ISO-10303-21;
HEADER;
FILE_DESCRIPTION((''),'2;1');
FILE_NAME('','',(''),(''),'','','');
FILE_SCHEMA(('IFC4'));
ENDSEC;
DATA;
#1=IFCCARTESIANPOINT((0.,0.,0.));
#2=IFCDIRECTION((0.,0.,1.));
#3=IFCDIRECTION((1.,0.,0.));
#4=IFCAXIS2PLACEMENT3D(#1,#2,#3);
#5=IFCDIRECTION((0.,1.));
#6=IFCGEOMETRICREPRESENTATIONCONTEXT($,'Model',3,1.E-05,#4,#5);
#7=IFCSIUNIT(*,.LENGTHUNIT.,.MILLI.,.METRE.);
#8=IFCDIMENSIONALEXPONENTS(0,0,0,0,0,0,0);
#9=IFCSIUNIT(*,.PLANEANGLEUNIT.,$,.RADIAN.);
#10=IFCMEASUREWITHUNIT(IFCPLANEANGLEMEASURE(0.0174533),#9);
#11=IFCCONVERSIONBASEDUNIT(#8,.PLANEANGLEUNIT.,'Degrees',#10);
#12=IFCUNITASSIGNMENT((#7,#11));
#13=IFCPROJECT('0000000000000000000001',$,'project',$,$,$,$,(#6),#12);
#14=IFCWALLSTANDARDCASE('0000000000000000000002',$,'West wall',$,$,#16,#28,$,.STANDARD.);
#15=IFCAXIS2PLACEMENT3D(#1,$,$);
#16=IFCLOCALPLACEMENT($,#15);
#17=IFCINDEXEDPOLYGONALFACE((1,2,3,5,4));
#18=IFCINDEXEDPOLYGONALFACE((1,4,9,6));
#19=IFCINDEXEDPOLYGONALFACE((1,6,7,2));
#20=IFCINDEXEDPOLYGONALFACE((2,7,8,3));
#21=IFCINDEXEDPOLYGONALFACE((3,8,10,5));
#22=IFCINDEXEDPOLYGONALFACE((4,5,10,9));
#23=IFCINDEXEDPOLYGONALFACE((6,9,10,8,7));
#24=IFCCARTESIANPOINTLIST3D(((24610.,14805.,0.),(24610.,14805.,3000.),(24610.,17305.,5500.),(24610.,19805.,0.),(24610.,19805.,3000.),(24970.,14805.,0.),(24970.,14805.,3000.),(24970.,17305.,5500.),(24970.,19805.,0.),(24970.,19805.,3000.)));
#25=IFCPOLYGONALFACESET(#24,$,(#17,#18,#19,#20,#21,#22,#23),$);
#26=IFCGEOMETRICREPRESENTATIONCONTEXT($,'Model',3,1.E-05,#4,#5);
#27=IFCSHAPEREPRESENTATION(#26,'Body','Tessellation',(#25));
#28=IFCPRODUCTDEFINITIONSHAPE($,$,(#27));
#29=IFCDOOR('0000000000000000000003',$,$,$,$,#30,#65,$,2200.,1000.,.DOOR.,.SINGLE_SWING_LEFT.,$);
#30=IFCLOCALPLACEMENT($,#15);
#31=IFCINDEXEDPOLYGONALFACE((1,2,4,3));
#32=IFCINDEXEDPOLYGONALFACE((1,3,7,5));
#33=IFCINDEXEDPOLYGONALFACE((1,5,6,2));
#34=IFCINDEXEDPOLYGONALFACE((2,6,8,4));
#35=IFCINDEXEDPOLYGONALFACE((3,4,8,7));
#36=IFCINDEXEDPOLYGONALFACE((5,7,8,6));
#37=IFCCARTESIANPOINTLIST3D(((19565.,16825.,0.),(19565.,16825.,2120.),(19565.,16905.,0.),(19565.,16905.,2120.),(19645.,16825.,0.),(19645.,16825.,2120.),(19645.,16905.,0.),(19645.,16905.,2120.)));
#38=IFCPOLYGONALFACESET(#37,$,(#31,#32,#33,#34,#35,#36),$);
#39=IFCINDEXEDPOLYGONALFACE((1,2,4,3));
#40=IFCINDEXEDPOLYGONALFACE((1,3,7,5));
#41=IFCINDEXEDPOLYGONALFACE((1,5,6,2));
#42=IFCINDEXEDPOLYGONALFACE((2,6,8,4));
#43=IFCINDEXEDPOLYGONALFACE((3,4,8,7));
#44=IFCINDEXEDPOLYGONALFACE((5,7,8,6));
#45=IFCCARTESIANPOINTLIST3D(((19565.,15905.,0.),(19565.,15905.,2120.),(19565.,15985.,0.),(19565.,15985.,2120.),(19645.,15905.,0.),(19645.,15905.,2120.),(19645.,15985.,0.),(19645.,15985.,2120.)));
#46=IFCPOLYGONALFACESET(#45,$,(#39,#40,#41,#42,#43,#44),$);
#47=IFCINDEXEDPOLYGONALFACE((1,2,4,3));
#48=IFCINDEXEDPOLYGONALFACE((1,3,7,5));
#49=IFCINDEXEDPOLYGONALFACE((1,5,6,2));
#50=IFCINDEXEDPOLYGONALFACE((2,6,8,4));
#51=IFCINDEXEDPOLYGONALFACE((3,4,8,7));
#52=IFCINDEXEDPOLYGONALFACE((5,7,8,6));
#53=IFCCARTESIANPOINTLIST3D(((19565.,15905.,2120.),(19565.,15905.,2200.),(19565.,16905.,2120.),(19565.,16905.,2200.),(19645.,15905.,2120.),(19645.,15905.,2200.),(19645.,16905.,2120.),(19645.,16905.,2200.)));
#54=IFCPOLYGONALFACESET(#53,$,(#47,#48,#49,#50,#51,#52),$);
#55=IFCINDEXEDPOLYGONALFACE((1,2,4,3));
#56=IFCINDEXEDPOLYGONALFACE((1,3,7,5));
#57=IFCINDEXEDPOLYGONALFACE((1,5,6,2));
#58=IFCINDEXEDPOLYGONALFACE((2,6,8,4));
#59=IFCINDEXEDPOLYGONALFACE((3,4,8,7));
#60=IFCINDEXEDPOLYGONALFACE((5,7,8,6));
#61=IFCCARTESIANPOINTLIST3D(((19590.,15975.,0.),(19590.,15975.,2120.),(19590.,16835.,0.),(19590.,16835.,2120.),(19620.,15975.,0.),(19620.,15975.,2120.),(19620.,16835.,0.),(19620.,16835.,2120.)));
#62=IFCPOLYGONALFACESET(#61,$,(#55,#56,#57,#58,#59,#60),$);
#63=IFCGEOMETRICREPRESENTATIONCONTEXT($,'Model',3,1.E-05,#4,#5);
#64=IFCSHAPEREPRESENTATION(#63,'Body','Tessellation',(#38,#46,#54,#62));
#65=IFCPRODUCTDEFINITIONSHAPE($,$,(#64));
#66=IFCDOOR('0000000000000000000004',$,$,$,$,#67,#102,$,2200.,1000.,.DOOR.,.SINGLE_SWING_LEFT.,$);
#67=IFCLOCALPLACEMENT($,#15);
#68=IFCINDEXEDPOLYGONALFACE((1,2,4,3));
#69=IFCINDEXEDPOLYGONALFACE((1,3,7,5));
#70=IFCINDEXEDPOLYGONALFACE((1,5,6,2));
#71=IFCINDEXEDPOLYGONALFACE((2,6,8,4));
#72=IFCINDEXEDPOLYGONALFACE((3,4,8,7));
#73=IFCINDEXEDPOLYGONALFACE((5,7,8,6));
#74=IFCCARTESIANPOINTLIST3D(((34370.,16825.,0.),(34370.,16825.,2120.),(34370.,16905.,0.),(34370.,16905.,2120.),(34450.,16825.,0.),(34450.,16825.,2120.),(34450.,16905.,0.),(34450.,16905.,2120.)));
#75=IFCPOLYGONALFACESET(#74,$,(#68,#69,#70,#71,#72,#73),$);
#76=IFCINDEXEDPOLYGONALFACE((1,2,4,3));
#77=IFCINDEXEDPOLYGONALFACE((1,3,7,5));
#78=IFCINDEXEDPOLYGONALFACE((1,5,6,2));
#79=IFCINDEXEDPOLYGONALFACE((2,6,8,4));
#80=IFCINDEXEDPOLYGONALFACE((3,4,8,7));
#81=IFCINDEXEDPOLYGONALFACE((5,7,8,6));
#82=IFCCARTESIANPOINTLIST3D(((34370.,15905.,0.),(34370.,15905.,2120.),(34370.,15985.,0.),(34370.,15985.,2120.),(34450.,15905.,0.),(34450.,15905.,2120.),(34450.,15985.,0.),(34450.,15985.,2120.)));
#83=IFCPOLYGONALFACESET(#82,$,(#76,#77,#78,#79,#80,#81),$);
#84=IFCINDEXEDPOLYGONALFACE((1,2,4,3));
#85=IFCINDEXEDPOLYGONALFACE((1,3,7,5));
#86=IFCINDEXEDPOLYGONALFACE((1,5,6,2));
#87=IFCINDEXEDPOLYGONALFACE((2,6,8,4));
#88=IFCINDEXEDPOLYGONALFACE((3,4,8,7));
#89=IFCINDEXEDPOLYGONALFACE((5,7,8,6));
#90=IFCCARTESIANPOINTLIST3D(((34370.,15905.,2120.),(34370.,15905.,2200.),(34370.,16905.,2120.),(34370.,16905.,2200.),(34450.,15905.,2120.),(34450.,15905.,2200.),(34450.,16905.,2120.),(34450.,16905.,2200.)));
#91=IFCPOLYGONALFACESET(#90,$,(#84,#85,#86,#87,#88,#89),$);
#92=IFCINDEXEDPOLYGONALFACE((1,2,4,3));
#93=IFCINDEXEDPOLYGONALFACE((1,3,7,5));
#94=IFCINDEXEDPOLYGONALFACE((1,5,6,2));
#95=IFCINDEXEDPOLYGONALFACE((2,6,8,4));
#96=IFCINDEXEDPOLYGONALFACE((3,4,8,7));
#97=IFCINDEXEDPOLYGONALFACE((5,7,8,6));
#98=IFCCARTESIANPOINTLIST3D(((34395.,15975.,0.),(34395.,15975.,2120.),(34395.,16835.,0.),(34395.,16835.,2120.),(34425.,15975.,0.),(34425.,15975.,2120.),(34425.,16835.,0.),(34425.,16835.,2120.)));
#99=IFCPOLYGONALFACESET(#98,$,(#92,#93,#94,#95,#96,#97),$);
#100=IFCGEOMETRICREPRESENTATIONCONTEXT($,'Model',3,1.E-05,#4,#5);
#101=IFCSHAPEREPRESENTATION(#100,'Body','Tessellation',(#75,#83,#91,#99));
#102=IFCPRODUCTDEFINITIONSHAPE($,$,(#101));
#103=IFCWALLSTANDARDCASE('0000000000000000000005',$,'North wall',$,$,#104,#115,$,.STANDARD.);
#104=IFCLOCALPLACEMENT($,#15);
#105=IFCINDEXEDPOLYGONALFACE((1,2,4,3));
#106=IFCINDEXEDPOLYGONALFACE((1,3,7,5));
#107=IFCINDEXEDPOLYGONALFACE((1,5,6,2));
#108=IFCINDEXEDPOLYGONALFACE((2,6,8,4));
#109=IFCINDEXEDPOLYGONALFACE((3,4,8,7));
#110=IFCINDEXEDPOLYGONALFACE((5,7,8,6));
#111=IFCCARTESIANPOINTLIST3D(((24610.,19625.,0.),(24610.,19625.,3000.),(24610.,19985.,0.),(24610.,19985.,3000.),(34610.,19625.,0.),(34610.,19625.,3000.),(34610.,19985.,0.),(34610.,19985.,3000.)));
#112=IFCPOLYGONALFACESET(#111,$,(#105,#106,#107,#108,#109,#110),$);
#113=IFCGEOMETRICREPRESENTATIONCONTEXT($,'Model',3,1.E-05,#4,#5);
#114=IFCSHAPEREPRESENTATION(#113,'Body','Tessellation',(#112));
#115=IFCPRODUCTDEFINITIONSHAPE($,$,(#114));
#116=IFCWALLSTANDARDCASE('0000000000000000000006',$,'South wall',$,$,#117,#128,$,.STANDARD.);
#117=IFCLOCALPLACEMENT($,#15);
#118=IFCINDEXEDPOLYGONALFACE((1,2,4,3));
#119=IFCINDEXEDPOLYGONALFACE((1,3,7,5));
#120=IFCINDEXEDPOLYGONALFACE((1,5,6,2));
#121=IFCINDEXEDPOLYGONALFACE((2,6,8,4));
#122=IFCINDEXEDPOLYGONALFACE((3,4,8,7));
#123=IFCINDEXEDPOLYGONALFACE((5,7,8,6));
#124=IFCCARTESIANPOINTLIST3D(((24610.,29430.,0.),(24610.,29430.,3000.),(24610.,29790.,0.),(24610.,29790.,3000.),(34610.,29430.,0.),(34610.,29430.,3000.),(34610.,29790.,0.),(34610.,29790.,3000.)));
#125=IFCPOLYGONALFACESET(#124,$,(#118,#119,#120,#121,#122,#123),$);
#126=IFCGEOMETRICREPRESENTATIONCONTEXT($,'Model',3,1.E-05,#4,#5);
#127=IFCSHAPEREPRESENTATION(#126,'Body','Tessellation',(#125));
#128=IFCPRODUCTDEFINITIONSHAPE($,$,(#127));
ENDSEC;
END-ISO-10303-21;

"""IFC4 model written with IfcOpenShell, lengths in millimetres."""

from ifc_helpers import new_model, entity, si_unit, converted_unit, direction, frame, origin_with_axes, place, context, project, polyline, outline, extrude, clip, halfspace, source, transform, mapped, element, save


model = new_model("IFC4")

# Units and contexts
model_context_1 = context("Model", 3, precision=1e-05, world=origin_with_axes(), true_north=direction((0.0, 1.0)))
model_context_2 = context("Model", 3, precision=1e-05, world=origin_with_axes(), true_north=direction((0.0, 1.0)))
model_context_3 = context("Model", 3, precision=1e-05, world=origin_with_axes(), true_north=direction((0.0, 1.0)))
model_context_4 = context("Model", 3, precision=1e-05, world=origin_with_axes(), true_north=direction((0.0, 1.0)))
model_context_5 = context("Model", 3, precision=1e-05, world=origin_with_axes(), true_north=direction((0.0, 1.0)))
model_context_6 = context("Model", 3, precision=1e-05, world=origin_with_axes(), true_north=direction((0.0, 1.0)))
ifc_project = project(units=[si_unit("LENGTHUNIT", "METRE", prefix="MILLI"), converted_unit("PLANEANGLEUNIT", "Degrees", entity("IfcPlaneAngleMeasure", 0.0174533), si_unit("PLANEANGLEUNIT", "RADIAN"), dimensions=[0, 0, 0, 0, 0, 0, 0])], contexts=[model_context_1])

# Shared definitions
placement_1 = place(None, frame((29610.0, 14805.0, 0.0)))

# Shared definitions
placement_2 = place(None, frame((29610.0, 29610.0, 0.0)))

# Wall
placement_3 = place(None, frame((14805.0, 14805.0, 0.0)))
shared_shape_1 = source(origin_with_axes(), model_context_5, "Body", "Clipping", [
    clip(clip(extrude(outline(polyline([(-2500.0, -180.0), (2500.0, -180.0), (2500.0, 180.0), (-2500.0, 180.0), (-2500.0, -180.0), (-2500.0, -180.0)])), origin_with_axes(), (0.0, 0.0, 1.0), 6000.0), halfspace(frame((-2500.0, 0.0, 3000.0), z_axis=(-1.0, 0.0, 1.0), x_axis=(1.0, 0.0, 0.0)), False)), halfspace(frame((2500.0, 0.0, 3000.0), z_axis=(1.0, 0.0, 1.0), x_axis=(1.0, 0.0, 0.0)), False)),
])
wall_1_placement = place(placement_1, frame((-4820.0, 2500.0, 0.0), z_axis=(0.0, 0.0, 1.0), x_axis=(0.0, -1.0, 0.0)))
element("IfcWallStandardCase", 1, at=wall_1_placement, Name="West wall", PredefinedType="STANDARD", context=model_context_5, shape_type="MappedRepresentation", body=[
    mapped(shared_shape_1, transform((0.0, 0.0, 0.0))),
])

# Doors
door_1_placement = place(placement_3, frame((4800.0, 1600.0, 0.0), z_axis=(0.0, 0.0, 1.0), x_axis=(0.0, 1.0, 0.0)))
element("IfcDoor", 2, at=door_1_placement, OperationType="SINGLE_SWING_LEFT", OverallHeight=2200.0, OverallWidth=1000.0, PredefinedType="DOOR", context=model_context_2, shape_type="SweptSolid", body=[
    extrude(outline(polyline([(-40.0, -40.0), (40.0, -40.0), (40.0, 40.0), (-40.0, 40.0), (-40.0, -40.0), (-40.0, -40.0)])), frame((460.0, 0.0, 0.0), z_axis=(0.0, 0.0, 1.0), x_axis=(1.0, 0.0, 0.0)), (0.0, 0.0, 1.0), 2120.0),
    extrude(outline(polyline([(-40.0, -40.0), (40.0, -40.0), (40.0, 40.0), (-40.0, 40.0), (-40.0, -40.0), (-40.0, -40.0)])), frame((-460.0, 0.0, 0.0), z_axis=(0.0, 0.0, 1.0), x_axis=(1.0, 0.0, 0.0)), (0.0, 0.0, 1.0), 2120.0),
    extrude(outline(polyline([(-500.0, -40.0), (500.0, -40.0), (500.0, 40.0), (-500.0, 40.0), (-500.0, -40.0), (-500.0, -40.0)])), frame((0.0, 0.0, 2120.0), z_axis=(0.0, 0.0, 1.0), x_axis=(1.0, 0.0, 0.0)), (0.0, 0.0, 1.0), 80.0),
    extrude(outline(polyline([(-430.0, -15.0), (430.0, -15.0), (430.0, 15.0), (-430.0, 15.0), (-430.0, -15.0), (-430.0, -15.0)])), origin_with_axes(), (0.0, 0.0, 1.0), 2120.0),
])
door_2_placement = place(placement_1, frame((4800.0, 1600.0, 0.0), z_axis=(0.0, 0.0, 1.0), x_axis=(0.0, 1.0, 0.0)))
element("IfcDoor", 3, at=door_2_placement, OperationType="SINGLE_SWING_LEFT", OverallHeight=2200.0, OverallWidth=1000.0, PredefinedType="DOOR", context=model_context_3, shape_type="SweptSolid", body=[
    extrude(outline(polyline([(-40.0, -40.0), (40.0, -40.0), (40.0, 40.0), (-40.0, 40.0), (-40.0, -40.0), (-40.0, -40.0)])), frame((460.0, 0.0, 0.0), z_axis=(0.0, 0.0, 1.0), x_axis=(1.0, 0.0, 0.0)), (0.0, 0.0, 1.0), 2120.0),
    extrude(outline(polyline([(-40.0, -40.0), (40.0, -40.0), (40.0, 40.0), (-40.0, 40.0), (-40.0, -40.0), (-40.0, -40.0)])), frame((-460.0, 0.0, 0.0), z_axis=(0.0, 0.0, 1.0), x_axis=(1.0, 0.0, 0.0)), (0.0, 0.0, 1.0), 2120.0),
    extrude(outline(polyline([(-500.0, -40.0), (500.0, -40.0), (500.0, 40.0), (-500.0, 40.0), (-500.0, -40.0), (-500.0, -40.0)])), frame((0.0, 0.0, 2120.0), z_axis=(0.0, 0.0, 1.0), x_axis=(1.0, 0.0, 0.0)), (0.0, 0.0, 1.0), 80.0),
    extrude(outline(polyline([(-430.0, -15.0), (430.0, -15.0), (430.0, 15.0), (-430.0, 15.0), (-430.0, -15.0), (-430.0, -15.0)])), origin_with_axes(), (0.0, 0.0, 1.0), 2120.0),
])

# Walls
wall_2_placement = place(placement_1, frame((0.0, 5000.0, 0.0), z_axis=(0.0, 0.0, 1.0), x_axis=(1.0, 0.0, 0.0)))
element("IfcWallStandardCase", 4, at=wall_2_placement, Name="North wall", PredefinedType="STANDARD", context=model_context_4, shape_type="SweptSolid", body=[
    extrude(outline(polyline([(-5000.0, -180.0), (5000.0, -180.0), (5000.0, 180.0), (-5000.0, 180.0), (-5000.0, -180.0), (-5000.0, -180.0)])), origin_with_axes(), (0.0, 0.0, 1.0), 3000.0),
])
wall_3_placement = place(placement_2, origin_with_axes())
element("IfcWallStandardCase", 5, at=wall_3_placement, Name="South wall", PredefinedType="STANDARD", context=model_context_6, shape_type="SweptSolid", body=[
    extrude(outline(polyline([(-5000.0, -180.0), (5000.0, -180.0), (5000.0, 180.0), (-5000.0, 180.0), (-5000.0, -180.0), (-5000.0, -180.0)])), origin_with_axes(), (0.0, 0.0, 1.0), 3000.0),
])

save(model, "model.ifc")
